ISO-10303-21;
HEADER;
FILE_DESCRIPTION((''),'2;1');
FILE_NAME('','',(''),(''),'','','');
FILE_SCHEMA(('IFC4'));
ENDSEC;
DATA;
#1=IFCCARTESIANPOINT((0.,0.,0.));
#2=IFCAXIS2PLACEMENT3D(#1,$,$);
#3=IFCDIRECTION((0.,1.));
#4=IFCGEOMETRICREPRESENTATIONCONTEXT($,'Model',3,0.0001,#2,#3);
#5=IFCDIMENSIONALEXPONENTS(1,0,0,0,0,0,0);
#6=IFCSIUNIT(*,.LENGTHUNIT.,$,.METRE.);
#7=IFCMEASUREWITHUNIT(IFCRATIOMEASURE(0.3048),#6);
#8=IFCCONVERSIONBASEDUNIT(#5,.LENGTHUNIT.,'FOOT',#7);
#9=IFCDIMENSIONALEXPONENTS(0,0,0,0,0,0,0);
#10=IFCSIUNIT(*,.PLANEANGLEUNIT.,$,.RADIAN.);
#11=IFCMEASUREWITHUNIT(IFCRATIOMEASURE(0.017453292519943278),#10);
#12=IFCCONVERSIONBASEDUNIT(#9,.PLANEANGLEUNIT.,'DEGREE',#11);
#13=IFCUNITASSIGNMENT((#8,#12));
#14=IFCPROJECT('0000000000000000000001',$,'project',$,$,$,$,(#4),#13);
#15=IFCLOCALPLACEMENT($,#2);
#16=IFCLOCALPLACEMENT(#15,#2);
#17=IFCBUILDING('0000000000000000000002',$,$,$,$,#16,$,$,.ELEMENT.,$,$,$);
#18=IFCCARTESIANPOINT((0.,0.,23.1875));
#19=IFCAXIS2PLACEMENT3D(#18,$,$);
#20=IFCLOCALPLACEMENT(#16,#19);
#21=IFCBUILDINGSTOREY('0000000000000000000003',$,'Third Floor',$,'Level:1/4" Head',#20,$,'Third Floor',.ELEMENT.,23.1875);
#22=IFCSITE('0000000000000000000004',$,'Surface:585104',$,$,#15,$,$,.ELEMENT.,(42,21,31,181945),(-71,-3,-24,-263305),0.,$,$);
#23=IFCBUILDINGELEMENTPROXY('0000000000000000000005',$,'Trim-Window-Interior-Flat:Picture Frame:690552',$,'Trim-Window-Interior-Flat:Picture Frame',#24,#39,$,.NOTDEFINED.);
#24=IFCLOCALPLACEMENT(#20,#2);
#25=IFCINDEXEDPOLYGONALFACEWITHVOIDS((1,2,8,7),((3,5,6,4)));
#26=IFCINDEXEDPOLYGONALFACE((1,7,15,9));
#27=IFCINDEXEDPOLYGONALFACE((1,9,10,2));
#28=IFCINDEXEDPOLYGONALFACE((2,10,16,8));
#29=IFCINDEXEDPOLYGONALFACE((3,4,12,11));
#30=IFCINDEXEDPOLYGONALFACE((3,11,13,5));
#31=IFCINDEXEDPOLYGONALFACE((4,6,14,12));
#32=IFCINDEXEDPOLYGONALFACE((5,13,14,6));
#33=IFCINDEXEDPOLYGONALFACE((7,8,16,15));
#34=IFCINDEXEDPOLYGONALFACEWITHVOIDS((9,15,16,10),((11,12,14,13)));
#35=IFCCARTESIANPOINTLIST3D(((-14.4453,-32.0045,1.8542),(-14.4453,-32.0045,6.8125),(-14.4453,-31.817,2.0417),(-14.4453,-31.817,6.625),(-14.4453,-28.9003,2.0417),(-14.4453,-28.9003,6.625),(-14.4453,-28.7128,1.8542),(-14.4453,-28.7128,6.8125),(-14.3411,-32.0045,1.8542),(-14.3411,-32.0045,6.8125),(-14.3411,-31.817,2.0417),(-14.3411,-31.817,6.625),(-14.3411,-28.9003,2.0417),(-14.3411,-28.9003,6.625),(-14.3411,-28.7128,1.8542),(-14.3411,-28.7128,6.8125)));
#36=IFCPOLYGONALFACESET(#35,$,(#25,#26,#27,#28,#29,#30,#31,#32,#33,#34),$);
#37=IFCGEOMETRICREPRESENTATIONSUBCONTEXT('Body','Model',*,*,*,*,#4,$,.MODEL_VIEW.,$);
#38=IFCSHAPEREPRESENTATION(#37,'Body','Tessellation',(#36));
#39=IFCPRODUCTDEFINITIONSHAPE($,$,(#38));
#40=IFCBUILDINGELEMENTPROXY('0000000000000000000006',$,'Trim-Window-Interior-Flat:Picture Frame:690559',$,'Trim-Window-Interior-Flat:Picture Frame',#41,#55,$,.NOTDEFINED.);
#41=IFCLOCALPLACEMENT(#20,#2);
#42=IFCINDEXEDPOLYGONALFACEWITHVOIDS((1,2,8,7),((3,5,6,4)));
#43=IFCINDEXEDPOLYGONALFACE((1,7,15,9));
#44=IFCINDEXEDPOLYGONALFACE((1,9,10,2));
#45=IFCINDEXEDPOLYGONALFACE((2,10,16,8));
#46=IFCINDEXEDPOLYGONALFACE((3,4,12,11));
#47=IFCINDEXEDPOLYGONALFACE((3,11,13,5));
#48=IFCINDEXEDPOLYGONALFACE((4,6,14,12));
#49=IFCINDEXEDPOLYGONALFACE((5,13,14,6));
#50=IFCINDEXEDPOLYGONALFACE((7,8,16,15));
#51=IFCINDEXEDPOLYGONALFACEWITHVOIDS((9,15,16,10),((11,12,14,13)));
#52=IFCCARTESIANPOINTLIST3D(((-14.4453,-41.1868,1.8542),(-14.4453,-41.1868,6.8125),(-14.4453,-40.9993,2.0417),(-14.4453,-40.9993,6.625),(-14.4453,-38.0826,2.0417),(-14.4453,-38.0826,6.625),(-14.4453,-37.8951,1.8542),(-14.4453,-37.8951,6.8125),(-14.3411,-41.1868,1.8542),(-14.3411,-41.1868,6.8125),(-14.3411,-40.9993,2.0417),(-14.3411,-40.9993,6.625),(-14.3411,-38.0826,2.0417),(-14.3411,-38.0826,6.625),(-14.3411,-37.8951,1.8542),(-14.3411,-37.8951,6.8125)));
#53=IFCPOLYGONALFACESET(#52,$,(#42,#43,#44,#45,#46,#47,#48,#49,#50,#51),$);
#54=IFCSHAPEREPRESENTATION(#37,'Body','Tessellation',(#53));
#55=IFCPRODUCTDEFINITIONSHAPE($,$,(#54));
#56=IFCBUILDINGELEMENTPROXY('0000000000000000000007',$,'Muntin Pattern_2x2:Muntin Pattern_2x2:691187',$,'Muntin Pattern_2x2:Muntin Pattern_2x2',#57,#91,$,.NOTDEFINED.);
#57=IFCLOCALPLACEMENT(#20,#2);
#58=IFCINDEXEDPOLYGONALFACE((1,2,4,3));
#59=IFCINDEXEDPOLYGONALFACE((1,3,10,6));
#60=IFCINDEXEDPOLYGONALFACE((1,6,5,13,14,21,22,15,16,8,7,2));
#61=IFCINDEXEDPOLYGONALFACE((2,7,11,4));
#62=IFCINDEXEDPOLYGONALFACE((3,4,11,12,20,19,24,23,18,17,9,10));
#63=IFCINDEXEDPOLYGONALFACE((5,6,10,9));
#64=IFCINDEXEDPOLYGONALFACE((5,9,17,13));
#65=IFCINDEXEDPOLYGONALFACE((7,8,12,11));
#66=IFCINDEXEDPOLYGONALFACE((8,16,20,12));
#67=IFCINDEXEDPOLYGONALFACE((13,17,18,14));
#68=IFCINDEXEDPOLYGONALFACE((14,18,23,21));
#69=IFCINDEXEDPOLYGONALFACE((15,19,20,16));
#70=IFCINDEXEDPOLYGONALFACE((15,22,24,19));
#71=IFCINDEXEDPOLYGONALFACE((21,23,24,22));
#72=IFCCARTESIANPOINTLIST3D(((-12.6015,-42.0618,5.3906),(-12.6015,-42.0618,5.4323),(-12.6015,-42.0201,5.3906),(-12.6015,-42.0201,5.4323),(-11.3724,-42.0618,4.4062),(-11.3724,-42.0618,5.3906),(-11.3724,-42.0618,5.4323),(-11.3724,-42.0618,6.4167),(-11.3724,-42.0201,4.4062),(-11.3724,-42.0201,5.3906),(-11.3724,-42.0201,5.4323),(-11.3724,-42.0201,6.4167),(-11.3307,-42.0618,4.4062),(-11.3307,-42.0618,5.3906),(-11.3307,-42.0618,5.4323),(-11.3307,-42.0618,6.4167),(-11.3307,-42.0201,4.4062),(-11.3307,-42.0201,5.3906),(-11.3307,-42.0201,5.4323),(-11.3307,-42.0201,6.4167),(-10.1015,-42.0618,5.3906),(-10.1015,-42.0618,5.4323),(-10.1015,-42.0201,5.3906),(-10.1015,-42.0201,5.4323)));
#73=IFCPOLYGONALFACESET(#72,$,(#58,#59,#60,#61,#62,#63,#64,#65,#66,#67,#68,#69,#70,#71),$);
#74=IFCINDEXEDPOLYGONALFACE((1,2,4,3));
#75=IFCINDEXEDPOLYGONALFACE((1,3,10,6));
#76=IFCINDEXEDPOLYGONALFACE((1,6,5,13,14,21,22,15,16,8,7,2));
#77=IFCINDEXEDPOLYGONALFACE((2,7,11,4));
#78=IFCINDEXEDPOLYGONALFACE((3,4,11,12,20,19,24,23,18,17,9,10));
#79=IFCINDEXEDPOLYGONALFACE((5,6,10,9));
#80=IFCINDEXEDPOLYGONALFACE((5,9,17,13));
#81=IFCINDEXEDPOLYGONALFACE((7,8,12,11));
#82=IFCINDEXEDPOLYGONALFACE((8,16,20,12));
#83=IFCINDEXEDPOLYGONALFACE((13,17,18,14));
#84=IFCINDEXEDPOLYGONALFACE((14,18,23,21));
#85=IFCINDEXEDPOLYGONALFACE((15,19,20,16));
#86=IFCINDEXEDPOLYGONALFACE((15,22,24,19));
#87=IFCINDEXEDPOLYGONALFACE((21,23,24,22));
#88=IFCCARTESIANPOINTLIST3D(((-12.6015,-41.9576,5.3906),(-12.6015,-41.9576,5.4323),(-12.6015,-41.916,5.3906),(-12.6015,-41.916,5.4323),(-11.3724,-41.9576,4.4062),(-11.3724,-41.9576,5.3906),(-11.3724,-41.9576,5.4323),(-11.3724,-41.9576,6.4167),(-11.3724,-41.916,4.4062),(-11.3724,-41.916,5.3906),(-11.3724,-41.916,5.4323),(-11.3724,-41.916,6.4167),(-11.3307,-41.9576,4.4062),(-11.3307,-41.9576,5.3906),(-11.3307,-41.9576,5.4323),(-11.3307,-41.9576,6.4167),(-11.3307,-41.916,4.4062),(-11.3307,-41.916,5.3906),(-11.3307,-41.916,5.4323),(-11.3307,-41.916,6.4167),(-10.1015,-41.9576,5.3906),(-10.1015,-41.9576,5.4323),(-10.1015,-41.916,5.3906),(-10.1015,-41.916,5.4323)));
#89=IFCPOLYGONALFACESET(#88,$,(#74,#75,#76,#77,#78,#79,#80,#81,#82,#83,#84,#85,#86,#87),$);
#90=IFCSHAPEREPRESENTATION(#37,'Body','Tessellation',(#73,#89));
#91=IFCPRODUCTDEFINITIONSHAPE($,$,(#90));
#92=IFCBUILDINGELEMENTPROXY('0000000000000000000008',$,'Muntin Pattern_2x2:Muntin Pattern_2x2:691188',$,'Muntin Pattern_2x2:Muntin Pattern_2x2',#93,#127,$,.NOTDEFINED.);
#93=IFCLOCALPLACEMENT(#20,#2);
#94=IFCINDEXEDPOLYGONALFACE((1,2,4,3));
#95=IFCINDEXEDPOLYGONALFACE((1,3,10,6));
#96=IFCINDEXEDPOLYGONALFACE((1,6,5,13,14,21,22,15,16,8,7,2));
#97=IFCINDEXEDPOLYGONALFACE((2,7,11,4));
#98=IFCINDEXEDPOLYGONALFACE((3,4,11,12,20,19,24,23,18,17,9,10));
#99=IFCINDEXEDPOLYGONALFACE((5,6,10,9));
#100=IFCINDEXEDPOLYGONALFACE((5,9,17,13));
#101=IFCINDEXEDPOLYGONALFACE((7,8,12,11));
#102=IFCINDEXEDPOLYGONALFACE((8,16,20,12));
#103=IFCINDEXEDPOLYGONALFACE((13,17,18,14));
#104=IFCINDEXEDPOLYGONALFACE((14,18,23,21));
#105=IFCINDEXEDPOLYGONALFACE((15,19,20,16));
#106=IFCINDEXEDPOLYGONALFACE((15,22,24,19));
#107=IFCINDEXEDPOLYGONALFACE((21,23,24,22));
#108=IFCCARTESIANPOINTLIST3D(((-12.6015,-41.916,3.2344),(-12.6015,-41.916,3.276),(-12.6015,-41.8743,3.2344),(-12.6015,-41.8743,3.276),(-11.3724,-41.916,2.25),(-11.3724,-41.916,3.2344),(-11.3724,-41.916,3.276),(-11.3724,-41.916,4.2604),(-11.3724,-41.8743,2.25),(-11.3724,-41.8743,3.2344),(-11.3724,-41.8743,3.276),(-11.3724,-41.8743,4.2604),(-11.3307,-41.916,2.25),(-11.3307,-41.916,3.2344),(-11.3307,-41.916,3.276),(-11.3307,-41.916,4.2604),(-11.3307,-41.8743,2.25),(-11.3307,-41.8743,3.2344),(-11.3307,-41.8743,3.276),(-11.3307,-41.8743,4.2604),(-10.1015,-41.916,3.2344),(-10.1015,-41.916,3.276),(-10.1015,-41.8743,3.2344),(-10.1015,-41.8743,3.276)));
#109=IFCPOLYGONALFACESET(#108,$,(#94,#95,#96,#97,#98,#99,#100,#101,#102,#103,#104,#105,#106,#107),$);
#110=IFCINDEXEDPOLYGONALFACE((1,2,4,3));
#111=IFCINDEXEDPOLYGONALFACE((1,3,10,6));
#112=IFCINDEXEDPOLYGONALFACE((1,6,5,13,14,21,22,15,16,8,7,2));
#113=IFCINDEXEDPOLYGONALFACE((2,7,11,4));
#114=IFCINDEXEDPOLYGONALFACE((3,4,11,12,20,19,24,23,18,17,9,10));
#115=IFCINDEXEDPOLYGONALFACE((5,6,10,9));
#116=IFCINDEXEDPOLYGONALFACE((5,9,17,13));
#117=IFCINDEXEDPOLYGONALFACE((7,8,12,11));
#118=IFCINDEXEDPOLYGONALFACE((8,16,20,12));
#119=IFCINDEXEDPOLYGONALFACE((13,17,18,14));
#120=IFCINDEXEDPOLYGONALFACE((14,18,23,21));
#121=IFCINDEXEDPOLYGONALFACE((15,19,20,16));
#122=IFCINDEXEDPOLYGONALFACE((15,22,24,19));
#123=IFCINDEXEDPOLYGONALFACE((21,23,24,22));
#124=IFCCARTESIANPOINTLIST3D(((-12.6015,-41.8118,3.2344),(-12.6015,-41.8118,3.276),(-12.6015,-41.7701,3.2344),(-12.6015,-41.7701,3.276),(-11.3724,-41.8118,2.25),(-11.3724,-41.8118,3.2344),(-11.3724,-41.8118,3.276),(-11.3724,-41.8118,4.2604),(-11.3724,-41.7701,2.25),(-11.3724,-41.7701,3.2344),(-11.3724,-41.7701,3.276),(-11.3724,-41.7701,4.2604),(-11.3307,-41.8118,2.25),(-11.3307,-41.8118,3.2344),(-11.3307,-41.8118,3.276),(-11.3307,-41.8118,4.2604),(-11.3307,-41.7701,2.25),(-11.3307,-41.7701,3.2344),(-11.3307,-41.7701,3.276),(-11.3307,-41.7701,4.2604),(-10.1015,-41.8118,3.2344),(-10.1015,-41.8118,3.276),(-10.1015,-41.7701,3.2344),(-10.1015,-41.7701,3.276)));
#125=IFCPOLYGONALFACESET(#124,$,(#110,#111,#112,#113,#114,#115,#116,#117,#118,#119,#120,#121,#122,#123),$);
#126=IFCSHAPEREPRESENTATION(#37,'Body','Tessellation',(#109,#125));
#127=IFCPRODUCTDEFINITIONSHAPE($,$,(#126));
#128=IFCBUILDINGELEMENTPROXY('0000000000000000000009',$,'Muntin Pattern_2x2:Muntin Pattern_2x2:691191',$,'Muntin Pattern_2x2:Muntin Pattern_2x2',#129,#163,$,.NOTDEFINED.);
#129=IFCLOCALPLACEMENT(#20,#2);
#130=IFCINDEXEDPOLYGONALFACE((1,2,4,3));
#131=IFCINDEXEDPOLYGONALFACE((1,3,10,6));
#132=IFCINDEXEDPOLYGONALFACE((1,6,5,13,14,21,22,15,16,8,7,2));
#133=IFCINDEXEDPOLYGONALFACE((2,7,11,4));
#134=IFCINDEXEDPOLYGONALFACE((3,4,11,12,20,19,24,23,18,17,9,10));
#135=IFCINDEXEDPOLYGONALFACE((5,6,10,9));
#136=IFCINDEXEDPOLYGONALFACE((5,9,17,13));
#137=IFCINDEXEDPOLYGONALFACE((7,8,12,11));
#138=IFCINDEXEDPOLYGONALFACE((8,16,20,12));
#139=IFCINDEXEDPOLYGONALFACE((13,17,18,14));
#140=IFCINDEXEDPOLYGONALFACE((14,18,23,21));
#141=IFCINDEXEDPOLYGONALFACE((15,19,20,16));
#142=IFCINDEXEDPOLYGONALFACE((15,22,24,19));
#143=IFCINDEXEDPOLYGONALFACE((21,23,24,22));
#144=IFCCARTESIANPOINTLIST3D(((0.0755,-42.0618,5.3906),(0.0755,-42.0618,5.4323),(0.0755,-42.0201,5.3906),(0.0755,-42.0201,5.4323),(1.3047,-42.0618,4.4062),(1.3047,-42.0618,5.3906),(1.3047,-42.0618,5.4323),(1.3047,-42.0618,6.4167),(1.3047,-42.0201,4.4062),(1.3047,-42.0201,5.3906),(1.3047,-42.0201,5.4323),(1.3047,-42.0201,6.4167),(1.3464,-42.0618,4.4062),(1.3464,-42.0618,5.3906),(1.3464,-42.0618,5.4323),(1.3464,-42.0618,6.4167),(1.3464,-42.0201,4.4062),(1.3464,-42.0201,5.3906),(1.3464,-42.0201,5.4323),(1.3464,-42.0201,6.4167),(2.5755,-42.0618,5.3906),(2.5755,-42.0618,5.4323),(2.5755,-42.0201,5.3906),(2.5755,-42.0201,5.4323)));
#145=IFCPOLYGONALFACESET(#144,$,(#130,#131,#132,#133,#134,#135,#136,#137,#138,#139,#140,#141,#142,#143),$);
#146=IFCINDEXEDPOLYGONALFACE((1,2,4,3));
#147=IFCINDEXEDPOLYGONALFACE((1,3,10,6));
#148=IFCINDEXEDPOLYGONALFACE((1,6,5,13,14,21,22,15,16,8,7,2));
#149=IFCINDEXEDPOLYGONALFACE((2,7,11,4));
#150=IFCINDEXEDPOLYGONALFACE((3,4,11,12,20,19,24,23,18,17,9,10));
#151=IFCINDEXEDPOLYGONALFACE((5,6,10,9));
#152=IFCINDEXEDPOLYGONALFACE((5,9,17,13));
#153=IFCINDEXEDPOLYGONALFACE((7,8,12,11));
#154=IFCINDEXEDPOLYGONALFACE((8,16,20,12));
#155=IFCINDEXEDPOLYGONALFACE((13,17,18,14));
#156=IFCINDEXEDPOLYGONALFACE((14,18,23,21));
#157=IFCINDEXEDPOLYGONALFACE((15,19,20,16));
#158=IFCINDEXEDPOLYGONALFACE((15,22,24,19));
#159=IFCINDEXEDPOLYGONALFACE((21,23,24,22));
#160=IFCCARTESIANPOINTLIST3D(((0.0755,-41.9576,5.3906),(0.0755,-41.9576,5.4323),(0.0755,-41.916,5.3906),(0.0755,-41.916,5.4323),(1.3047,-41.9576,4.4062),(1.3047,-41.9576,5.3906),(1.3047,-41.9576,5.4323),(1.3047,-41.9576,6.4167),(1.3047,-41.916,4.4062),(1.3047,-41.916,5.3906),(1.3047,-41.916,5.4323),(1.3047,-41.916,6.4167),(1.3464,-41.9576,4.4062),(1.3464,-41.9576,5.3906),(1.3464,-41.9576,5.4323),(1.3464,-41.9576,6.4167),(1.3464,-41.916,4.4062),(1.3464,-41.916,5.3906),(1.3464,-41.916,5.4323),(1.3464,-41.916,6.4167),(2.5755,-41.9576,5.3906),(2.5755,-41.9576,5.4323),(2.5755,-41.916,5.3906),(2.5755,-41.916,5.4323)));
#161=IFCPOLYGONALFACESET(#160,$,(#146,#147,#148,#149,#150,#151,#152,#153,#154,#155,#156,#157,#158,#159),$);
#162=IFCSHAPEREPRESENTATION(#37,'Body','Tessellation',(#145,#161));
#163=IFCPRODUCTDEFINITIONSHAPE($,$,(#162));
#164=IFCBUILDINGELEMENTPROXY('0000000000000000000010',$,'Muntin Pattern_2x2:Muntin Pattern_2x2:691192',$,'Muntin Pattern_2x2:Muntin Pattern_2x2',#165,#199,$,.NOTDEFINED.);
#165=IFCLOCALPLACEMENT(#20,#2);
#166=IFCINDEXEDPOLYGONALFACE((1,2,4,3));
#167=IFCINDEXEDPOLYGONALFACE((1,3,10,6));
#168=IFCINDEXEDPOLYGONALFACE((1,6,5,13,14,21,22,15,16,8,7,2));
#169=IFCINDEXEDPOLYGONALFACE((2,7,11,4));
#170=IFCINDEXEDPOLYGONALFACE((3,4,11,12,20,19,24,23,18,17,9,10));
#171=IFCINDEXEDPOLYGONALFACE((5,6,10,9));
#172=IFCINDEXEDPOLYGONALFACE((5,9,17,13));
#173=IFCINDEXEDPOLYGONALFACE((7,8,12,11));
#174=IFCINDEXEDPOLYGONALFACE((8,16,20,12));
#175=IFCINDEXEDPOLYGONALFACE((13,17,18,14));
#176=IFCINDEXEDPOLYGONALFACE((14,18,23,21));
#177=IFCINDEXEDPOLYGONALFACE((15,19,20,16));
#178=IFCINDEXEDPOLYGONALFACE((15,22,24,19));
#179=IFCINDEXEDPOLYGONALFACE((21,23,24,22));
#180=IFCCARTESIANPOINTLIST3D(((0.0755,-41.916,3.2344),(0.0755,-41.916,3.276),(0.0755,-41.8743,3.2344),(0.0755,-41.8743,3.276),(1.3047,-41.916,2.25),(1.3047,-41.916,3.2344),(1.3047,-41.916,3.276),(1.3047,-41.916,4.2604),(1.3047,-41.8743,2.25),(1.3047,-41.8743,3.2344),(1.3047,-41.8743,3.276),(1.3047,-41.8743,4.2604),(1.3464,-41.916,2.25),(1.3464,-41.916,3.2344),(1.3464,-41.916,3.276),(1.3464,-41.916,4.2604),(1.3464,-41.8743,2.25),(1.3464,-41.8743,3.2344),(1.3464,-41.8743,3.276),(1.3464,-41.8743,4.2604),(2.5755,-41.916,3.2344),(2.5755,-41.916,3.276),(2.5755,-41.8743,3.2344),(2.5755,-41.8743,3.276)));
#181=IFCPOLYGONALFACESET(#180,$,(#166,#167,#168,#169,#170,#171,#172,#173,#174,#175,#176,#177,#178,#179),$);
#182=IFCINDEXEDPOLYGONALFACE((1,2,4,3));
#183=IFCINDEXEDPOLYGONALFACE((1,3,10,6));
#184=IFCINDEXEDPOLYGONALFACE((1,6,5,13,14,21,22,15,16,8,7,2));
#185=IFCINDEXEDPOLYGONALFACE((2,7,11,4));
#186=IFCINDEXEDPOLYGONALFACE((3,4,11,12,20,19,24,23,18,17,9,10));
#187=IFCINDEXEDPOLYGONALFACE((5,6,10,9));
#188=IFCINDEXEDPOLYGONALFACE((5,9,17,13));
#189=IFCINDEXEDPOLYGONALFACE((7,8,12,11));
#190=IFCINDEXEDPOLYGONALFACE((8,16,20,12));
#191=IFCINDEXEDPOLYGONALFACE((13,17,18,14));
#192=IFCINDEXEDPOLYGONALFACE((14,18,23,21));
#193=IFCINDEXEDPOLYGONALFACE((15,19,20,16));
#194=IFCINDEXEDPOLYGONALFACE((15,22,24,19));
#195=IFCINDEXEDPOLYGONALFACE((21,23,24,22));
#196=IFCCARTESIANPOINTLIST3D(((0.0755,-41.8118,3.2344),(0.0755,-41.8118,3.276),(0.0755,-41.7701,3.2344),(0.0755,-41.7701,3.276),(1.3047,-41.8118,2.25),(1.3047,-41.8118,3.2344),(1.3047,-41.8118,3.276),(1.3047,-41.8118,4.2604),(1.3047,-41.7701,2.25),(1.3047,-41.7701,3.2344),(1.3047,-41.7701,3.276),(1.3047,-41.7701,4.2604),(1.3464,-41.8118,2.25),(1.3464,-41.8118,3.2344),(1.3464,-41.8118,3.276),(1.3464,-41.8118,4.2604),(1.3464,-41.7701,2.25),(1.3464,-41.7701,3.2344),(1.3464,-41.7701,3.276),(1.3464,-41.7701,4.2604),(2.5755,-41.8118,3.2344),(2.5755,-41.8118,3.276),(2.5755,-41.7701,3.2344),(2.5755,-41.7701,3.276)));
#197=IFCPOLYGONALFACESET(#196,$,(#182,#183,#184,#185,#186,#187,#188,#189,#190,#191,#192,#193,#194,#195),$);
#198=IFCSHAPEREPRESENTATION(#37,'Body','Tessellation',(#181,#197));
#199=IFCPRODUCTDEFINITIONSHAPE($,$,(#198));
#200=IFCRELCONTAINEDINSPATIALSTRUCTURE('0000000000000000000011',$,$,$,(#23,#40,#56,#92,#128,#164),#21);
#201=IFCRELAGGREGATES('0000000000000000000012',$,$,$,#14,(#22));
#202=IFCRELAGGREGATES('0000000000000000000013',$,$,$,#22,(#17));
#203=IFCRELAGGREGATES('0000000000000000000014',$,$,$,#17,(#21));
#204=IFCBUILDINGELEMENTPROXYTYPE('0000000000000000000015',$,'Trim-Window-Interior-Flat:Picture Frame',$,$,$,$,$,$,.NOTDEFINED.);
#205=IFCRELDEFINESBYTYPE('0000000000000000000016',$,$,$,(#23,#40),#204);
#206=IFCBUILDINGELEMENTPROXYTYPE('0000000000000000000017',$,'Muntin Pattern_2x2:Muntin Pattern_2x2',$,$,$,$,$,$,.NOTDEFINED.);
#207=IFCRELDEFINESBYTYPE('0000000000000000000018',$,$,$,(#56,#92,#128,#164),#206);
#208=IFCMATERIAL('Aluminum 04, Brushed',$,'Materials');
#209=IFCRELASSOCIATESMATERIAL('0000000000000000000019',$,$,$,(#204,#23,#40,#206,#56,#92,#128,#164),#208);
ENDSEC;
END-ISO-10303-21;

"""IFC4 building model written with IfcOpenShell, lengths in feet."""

from ifc_helpers import new_model, entity, si_unit, converted_unit, direction, frame, origin, place, context, subcontext, project, spatial, indexed_curve, outline, extrude, source, transform, mapped, material, type_object, type_shapes, element, save


model = new_model("IFC4")

# Units and contexts
model_context = context("Model", 3, precision=0.0001, world=origin(), true_north=direction((0.0, 1.0)))
body_context = subcontext(model_context, "Body", "Model", "MODEL_VIEW")
ifc_project = project(units=[converted_unit("LENGTHUNIT", "FOOT", entity("IfcRatioMeasure", 0.3048), si_unit("LENGTHUNIT", "METRE"), dimensions=[1, 0, 0, 0, 0, 0, 0]), converted_unit("PLANEANGLEUNIT", "DEGREE", entity("IfcRatioMeasure", 0.017453292519943278), si_unit("PLANEANGLEUNIT", "RADIAN"), dimensions=[0, 0, 0, 0, 0, 0, 0])], contexts=[model_context])

# Site, building, storey
site_placement = place(None, origin())
site = spatial("IfcSite", under=ifc_project, at=site_placement, Name="Surface:585104", CompositionType="ELEMENT", RefLatitude=(42, 21, 31, 181945), RefLongitude=(-71, -3, -24, -263305), RefElevation=0.0)
building_placement = place(site_placement, origin())
building = spatial("IfcBuilding", under=site, at=building_placement, CompositionType="ELEMENT")
storey_placement = place(building_placement, frame((0.0, 0.0, 23.1875)))
storey = spatial("IfcBuildingStorey", under=building, at=storey_placement, Name="Third Floor", ObjectType="Level:1/4\" Head", LongName="Third Floor", CompositionType="ELEMENT", Elevation=23.1875)

# Shared definitions
ifc_material_1 = material(Name="Aluminum 04, Brushed", Category="Materials")

# Building element proxies
building_element_proxy_type_1 = type_object("IfcBuildingElementProxyType", Name="Trim-Window-Interior-Flat:Picture Frame", PredefinedType="NOTDEFINED", material=ifc_material_1)
shared_shape_1 = source(origin(), body_context, "Body", "SweptSolid", [
    extrude(outline(indexed_curve([(-2.4792, -1.6458), (2.4792, -1.6458), (2.4792, 1.6458), (-2.4792, 1.6458), (-2.4792, -1.6458)], self_intersect=False), holes=[indexed_curve([(-2.2917, -1.4583), (-2.2917, 1.4583), (2.2917, 1.4583), (2.2917, -1.4583), (-2.2917, -1.4583)], self_intersect=False)]), frame((0.0, 2.3333, 0.0), z_axis=(0.0, 0.0, 1.0), x_axis=(0.0, 1.0, 0.0)), (0.0, 0.0, 1.0), 0.1042),
])
type_shapes(building_element_proxy_type_1, [shared_shape_1])
for number, where, z_axis, x_axis, name in (
    (1, (-14.3411, -30.3587, 6.6667), (-1.0, 0.0, 0.0), (0.0, 1.0, 0.0), "Trim-Window-Interior-Flat:Picture Frame:690552"),
    (2, (-14.3411, -39.541, 6.6667), (-1.0, 0.0, 0.0), (0.0, 1.0, 0.0), "Trim-Window-Interior-Flat:Picture Frame:690559"),
):
    element("IfcBuildingElementProxy", number, at=place(storey_placement, frame(where, z_axis=z_axis, x_axis=x_axis)), inside=storey, type_object=building_element_proxy_type_1, material=ifc_material_1, Name=name, ObjectType="Trim-Window-Interior-Flat:Picture Frame", PredefinedType="NOTDEFINED", context=body_context, shape_type="MappedRepresentation", body=[
        mapped(shared_shape_1, transform((0.0, 0.0, 0.0), scale=1.0)),
    ])
building_element_proxy_type_2 = type_object("IfcBuildingElementProxyType", Name="Muntin Pattern_2x2:Muntin Pattern_2x2", PredefinedType="NOTDEFINED", material=ifc_material_1)
shared_shape_2 = source(origin(), body_context, "Body", "SweptSolid", [
    extrude(outline(indexed_curve([(0.0208, -0.0208), (1.0052, -0.0208), (1.0052, 0.0208), (0.0208, 0.0208), (0.0208, 1.25), (-0.0208, 1.25), (-0.0208, 0.0208), (-1.0052, 0.0208), (-1.0052, -0.0208), (-0.0208, -0.0208), (-0.0208, -1.25), (0.0208, -1.25), (0.0208, -0.0208)], self_intersect=False)), frame((0.0, 0.0312, 1.0052), z_axis=(0.0, 1.0, 0.0), x_axis=(0.0, 0.0, 1.0)), (0.0, 0.0, 1.0), 0.0417),
    extrude(outline(indexed_curve([(0.0208, -0.0208), (1.0052, -0.0208), (1.0052, 0.0208), (0.0208, 0.0208), (0.0208, 1.25), (-0.0208, 1.25), (-0.0208, 0.0208), (-1.0052, 0.0208), (-1.0052, -0.0208), (-0.0208, -0.0208), (-0.0208, -1.25), (0.0208, -1.25), (0.0208, -0.0208)], self_intersect=False)), frame((0.0, -0.0729, 1.0052), z_axis=(0.0, 1.0, 0.0), x_axis=(0.0, 0.0, 1.0)), (0.0, 0.0, 1.0), 0.0417),
])
type_shapes(building_element_proxy_type_2, [shared_shape_2])
for number, where, z_axis, x_axis, name in (
    (3, (-11.3515, -41.9889, 4.4062), (0.0, 0.0, 1.0), (-1.0, 0.0, 0.0), "Muntin Pattern_2x2:Muntin Pattern_2x2:691187"),
    (4, (-11.3515, -41.843, 2.25), (0.0, 0.0, 1.0), (-1.0, 0.0, 0.0), "Muntin Pattern_2x2:Muntin Pattern_2x2:691188"),
    (5, (1.3255, -41.9889, 4.4062), (0.0, 0.0, 1.0), (-1.0, 0.0, 0.0), "Muntin Pattern_2x2:Muntin Pattern_2x2:691191"),
    (6, (1.3255, -41.843, 2.25), (0.0, 0.0, 1.0), (-1.0, 0.0, 0.0), "Muntin Pattern_2x2:Muntin Pattern_2x2:691192"),
):
    element("IfcBuildingElementProxy", number, at=place(storey_placement, frame(where, z_axis=z_axis, x_axis=x_axis)), inside=storey, type_object=building_element_proxy_type_2, material=ifc_material_1, Name=name, ObjectType="Muntin Pattern_2x2:Muntin Pattern_2x2", PredefinedType="NOTDEFINED", context=body_context, shape_type="MappedRepresentation", body=[
        mapped(shared_shape_2, transform((0.0, 0.0, 0.0), scale=1.0)),
    ])

save(model, "model.ifc")
